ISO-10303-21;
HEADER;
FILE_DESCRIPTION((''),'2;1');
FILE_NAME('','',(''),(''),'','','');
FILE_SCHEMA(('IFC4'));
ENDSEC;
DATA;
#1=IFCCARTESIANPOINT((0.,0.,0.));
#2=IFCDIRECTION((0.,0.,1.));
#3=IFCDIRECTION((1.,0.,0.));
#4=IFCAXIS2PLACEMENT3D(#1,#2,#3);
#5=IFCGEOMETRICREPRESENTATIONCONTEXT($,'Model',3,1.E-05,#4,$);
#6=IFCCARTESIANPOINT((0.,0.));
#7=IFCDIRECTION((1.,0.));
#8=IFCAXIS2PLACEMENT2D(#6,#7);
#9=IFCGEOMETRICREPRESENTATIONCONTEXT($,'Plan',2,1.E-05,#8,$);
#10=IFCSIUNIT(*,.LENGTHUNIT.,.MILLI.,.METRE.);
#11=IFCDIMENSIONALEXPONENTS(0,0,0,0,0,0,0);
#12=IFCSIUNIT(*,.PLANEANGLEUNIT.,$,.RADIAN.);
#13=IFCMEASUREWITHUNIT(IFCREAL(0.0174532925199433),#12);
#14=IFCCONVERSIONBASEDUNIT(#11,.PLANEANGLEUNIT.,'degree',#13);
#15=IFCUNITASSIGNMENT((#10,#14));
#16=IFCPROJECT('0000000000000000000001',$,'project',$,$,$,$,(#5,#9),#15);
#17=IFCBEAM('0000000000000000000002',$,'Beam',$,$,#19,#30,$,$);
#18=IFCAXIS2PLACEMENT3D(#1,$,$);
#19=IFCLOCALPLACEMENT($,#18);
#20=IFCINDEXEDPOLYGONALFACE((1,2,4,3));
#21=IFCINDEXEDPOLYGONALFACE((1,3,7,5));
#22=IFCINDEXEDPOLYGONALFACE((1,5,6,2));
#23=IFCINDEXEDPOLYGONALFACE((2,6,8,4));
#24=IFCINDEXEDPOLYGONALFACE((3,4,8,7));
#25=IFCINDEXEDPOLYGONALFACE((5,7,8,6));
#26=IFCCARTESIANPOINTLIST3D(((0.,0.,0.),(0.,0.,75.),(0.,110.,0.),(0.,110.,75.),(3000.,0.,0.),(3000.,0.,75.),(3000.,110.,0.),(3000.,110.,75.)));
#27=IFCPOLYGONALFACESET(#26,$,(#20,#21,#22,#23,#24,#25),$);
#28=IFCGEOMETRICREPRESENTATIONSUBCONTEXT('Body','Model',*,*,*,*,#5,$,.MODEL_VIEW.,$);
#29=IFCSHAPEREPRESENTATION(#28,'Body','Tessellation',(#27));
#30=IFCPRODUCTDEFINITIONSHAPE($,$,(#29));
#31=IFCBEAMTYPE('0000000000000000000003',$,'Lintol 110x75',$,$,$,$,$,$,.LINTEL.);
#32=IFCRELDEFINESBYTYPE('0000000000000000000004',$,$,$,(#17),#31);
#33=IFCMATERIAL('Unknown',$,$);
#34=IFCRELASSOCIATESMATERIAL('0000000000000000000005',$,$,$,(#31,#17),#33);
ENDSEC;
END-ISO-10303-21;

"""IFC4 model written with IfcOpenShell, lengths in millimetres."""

from ifc_helpers import new_model, entity, si_unit, converted_unit, frame, origin_with_axes, origin_2d_with_axis, place, context, subcontext, project, rectangle, extrude, material, material_profile, profile_set, profile_usage, type_object, element, save


model = new_model("IFC4")

# Units and contexts
model_context = context("Model", 3, precision=1e-05, world=origin_with_axes())
plan_context = context("Plan", 2, precision=1e-05, world=origin_2d_with_axis())
body_context = subcontext(model_context, "Body", "Model", "MODEL_VIEW")
ifc_project = project(units=[si_unit("LENGTHUNIT", "METRE", prefix="MILLI"), converted_unit("PLANEANGLEUNIT", "degree", entity("IfcReal", 0.0174532925199433), si_unit("PLANEANGLEUNIT", "RADIAN"), dimensions=[0, 0, 0, 0, 0, 0, 0])], contexts=[model_context, plan_context])

# Beam
ifc_material = material(Name="Unknown")
ifc_material_profile = material_profile(ifc_material, rectangle(XDim=110.0, YDim=75.0))
ifc_profile_set = profile_set([ifc_material_profile])
ifc_profile_usage = profile_usage(ifc_profile_set, cardinal=3)
beam_type = type_object("IfcBeamType", Name="Lintol 110x75", PredefinedType="LINTEL", material=ifc_profile_set)
beam_placement = place(None, frame((0.0, 0.0, 0.0), z_axis=(1.0, 0.0, 0.0), x_axis=(0.0, 1.0, 0.0)))
element("IfcBeam", 1, at=beam_placement, type_object=beam_type, material=ifc_profile_usage, Name="Beam", context=body_context, shape_type="SweptSolid", body=[
    extrude(rectangle(XDim=110.0, YDim=75.0), frame((55.0, 37.5, 0.0), z_axis=(0.0, 0.0, 1.0), x_axis=(1.0, 0.0, 0.0)), (0.0, 0.0, 1.0), 3000.0),
])

save(model, "model.ifc")
